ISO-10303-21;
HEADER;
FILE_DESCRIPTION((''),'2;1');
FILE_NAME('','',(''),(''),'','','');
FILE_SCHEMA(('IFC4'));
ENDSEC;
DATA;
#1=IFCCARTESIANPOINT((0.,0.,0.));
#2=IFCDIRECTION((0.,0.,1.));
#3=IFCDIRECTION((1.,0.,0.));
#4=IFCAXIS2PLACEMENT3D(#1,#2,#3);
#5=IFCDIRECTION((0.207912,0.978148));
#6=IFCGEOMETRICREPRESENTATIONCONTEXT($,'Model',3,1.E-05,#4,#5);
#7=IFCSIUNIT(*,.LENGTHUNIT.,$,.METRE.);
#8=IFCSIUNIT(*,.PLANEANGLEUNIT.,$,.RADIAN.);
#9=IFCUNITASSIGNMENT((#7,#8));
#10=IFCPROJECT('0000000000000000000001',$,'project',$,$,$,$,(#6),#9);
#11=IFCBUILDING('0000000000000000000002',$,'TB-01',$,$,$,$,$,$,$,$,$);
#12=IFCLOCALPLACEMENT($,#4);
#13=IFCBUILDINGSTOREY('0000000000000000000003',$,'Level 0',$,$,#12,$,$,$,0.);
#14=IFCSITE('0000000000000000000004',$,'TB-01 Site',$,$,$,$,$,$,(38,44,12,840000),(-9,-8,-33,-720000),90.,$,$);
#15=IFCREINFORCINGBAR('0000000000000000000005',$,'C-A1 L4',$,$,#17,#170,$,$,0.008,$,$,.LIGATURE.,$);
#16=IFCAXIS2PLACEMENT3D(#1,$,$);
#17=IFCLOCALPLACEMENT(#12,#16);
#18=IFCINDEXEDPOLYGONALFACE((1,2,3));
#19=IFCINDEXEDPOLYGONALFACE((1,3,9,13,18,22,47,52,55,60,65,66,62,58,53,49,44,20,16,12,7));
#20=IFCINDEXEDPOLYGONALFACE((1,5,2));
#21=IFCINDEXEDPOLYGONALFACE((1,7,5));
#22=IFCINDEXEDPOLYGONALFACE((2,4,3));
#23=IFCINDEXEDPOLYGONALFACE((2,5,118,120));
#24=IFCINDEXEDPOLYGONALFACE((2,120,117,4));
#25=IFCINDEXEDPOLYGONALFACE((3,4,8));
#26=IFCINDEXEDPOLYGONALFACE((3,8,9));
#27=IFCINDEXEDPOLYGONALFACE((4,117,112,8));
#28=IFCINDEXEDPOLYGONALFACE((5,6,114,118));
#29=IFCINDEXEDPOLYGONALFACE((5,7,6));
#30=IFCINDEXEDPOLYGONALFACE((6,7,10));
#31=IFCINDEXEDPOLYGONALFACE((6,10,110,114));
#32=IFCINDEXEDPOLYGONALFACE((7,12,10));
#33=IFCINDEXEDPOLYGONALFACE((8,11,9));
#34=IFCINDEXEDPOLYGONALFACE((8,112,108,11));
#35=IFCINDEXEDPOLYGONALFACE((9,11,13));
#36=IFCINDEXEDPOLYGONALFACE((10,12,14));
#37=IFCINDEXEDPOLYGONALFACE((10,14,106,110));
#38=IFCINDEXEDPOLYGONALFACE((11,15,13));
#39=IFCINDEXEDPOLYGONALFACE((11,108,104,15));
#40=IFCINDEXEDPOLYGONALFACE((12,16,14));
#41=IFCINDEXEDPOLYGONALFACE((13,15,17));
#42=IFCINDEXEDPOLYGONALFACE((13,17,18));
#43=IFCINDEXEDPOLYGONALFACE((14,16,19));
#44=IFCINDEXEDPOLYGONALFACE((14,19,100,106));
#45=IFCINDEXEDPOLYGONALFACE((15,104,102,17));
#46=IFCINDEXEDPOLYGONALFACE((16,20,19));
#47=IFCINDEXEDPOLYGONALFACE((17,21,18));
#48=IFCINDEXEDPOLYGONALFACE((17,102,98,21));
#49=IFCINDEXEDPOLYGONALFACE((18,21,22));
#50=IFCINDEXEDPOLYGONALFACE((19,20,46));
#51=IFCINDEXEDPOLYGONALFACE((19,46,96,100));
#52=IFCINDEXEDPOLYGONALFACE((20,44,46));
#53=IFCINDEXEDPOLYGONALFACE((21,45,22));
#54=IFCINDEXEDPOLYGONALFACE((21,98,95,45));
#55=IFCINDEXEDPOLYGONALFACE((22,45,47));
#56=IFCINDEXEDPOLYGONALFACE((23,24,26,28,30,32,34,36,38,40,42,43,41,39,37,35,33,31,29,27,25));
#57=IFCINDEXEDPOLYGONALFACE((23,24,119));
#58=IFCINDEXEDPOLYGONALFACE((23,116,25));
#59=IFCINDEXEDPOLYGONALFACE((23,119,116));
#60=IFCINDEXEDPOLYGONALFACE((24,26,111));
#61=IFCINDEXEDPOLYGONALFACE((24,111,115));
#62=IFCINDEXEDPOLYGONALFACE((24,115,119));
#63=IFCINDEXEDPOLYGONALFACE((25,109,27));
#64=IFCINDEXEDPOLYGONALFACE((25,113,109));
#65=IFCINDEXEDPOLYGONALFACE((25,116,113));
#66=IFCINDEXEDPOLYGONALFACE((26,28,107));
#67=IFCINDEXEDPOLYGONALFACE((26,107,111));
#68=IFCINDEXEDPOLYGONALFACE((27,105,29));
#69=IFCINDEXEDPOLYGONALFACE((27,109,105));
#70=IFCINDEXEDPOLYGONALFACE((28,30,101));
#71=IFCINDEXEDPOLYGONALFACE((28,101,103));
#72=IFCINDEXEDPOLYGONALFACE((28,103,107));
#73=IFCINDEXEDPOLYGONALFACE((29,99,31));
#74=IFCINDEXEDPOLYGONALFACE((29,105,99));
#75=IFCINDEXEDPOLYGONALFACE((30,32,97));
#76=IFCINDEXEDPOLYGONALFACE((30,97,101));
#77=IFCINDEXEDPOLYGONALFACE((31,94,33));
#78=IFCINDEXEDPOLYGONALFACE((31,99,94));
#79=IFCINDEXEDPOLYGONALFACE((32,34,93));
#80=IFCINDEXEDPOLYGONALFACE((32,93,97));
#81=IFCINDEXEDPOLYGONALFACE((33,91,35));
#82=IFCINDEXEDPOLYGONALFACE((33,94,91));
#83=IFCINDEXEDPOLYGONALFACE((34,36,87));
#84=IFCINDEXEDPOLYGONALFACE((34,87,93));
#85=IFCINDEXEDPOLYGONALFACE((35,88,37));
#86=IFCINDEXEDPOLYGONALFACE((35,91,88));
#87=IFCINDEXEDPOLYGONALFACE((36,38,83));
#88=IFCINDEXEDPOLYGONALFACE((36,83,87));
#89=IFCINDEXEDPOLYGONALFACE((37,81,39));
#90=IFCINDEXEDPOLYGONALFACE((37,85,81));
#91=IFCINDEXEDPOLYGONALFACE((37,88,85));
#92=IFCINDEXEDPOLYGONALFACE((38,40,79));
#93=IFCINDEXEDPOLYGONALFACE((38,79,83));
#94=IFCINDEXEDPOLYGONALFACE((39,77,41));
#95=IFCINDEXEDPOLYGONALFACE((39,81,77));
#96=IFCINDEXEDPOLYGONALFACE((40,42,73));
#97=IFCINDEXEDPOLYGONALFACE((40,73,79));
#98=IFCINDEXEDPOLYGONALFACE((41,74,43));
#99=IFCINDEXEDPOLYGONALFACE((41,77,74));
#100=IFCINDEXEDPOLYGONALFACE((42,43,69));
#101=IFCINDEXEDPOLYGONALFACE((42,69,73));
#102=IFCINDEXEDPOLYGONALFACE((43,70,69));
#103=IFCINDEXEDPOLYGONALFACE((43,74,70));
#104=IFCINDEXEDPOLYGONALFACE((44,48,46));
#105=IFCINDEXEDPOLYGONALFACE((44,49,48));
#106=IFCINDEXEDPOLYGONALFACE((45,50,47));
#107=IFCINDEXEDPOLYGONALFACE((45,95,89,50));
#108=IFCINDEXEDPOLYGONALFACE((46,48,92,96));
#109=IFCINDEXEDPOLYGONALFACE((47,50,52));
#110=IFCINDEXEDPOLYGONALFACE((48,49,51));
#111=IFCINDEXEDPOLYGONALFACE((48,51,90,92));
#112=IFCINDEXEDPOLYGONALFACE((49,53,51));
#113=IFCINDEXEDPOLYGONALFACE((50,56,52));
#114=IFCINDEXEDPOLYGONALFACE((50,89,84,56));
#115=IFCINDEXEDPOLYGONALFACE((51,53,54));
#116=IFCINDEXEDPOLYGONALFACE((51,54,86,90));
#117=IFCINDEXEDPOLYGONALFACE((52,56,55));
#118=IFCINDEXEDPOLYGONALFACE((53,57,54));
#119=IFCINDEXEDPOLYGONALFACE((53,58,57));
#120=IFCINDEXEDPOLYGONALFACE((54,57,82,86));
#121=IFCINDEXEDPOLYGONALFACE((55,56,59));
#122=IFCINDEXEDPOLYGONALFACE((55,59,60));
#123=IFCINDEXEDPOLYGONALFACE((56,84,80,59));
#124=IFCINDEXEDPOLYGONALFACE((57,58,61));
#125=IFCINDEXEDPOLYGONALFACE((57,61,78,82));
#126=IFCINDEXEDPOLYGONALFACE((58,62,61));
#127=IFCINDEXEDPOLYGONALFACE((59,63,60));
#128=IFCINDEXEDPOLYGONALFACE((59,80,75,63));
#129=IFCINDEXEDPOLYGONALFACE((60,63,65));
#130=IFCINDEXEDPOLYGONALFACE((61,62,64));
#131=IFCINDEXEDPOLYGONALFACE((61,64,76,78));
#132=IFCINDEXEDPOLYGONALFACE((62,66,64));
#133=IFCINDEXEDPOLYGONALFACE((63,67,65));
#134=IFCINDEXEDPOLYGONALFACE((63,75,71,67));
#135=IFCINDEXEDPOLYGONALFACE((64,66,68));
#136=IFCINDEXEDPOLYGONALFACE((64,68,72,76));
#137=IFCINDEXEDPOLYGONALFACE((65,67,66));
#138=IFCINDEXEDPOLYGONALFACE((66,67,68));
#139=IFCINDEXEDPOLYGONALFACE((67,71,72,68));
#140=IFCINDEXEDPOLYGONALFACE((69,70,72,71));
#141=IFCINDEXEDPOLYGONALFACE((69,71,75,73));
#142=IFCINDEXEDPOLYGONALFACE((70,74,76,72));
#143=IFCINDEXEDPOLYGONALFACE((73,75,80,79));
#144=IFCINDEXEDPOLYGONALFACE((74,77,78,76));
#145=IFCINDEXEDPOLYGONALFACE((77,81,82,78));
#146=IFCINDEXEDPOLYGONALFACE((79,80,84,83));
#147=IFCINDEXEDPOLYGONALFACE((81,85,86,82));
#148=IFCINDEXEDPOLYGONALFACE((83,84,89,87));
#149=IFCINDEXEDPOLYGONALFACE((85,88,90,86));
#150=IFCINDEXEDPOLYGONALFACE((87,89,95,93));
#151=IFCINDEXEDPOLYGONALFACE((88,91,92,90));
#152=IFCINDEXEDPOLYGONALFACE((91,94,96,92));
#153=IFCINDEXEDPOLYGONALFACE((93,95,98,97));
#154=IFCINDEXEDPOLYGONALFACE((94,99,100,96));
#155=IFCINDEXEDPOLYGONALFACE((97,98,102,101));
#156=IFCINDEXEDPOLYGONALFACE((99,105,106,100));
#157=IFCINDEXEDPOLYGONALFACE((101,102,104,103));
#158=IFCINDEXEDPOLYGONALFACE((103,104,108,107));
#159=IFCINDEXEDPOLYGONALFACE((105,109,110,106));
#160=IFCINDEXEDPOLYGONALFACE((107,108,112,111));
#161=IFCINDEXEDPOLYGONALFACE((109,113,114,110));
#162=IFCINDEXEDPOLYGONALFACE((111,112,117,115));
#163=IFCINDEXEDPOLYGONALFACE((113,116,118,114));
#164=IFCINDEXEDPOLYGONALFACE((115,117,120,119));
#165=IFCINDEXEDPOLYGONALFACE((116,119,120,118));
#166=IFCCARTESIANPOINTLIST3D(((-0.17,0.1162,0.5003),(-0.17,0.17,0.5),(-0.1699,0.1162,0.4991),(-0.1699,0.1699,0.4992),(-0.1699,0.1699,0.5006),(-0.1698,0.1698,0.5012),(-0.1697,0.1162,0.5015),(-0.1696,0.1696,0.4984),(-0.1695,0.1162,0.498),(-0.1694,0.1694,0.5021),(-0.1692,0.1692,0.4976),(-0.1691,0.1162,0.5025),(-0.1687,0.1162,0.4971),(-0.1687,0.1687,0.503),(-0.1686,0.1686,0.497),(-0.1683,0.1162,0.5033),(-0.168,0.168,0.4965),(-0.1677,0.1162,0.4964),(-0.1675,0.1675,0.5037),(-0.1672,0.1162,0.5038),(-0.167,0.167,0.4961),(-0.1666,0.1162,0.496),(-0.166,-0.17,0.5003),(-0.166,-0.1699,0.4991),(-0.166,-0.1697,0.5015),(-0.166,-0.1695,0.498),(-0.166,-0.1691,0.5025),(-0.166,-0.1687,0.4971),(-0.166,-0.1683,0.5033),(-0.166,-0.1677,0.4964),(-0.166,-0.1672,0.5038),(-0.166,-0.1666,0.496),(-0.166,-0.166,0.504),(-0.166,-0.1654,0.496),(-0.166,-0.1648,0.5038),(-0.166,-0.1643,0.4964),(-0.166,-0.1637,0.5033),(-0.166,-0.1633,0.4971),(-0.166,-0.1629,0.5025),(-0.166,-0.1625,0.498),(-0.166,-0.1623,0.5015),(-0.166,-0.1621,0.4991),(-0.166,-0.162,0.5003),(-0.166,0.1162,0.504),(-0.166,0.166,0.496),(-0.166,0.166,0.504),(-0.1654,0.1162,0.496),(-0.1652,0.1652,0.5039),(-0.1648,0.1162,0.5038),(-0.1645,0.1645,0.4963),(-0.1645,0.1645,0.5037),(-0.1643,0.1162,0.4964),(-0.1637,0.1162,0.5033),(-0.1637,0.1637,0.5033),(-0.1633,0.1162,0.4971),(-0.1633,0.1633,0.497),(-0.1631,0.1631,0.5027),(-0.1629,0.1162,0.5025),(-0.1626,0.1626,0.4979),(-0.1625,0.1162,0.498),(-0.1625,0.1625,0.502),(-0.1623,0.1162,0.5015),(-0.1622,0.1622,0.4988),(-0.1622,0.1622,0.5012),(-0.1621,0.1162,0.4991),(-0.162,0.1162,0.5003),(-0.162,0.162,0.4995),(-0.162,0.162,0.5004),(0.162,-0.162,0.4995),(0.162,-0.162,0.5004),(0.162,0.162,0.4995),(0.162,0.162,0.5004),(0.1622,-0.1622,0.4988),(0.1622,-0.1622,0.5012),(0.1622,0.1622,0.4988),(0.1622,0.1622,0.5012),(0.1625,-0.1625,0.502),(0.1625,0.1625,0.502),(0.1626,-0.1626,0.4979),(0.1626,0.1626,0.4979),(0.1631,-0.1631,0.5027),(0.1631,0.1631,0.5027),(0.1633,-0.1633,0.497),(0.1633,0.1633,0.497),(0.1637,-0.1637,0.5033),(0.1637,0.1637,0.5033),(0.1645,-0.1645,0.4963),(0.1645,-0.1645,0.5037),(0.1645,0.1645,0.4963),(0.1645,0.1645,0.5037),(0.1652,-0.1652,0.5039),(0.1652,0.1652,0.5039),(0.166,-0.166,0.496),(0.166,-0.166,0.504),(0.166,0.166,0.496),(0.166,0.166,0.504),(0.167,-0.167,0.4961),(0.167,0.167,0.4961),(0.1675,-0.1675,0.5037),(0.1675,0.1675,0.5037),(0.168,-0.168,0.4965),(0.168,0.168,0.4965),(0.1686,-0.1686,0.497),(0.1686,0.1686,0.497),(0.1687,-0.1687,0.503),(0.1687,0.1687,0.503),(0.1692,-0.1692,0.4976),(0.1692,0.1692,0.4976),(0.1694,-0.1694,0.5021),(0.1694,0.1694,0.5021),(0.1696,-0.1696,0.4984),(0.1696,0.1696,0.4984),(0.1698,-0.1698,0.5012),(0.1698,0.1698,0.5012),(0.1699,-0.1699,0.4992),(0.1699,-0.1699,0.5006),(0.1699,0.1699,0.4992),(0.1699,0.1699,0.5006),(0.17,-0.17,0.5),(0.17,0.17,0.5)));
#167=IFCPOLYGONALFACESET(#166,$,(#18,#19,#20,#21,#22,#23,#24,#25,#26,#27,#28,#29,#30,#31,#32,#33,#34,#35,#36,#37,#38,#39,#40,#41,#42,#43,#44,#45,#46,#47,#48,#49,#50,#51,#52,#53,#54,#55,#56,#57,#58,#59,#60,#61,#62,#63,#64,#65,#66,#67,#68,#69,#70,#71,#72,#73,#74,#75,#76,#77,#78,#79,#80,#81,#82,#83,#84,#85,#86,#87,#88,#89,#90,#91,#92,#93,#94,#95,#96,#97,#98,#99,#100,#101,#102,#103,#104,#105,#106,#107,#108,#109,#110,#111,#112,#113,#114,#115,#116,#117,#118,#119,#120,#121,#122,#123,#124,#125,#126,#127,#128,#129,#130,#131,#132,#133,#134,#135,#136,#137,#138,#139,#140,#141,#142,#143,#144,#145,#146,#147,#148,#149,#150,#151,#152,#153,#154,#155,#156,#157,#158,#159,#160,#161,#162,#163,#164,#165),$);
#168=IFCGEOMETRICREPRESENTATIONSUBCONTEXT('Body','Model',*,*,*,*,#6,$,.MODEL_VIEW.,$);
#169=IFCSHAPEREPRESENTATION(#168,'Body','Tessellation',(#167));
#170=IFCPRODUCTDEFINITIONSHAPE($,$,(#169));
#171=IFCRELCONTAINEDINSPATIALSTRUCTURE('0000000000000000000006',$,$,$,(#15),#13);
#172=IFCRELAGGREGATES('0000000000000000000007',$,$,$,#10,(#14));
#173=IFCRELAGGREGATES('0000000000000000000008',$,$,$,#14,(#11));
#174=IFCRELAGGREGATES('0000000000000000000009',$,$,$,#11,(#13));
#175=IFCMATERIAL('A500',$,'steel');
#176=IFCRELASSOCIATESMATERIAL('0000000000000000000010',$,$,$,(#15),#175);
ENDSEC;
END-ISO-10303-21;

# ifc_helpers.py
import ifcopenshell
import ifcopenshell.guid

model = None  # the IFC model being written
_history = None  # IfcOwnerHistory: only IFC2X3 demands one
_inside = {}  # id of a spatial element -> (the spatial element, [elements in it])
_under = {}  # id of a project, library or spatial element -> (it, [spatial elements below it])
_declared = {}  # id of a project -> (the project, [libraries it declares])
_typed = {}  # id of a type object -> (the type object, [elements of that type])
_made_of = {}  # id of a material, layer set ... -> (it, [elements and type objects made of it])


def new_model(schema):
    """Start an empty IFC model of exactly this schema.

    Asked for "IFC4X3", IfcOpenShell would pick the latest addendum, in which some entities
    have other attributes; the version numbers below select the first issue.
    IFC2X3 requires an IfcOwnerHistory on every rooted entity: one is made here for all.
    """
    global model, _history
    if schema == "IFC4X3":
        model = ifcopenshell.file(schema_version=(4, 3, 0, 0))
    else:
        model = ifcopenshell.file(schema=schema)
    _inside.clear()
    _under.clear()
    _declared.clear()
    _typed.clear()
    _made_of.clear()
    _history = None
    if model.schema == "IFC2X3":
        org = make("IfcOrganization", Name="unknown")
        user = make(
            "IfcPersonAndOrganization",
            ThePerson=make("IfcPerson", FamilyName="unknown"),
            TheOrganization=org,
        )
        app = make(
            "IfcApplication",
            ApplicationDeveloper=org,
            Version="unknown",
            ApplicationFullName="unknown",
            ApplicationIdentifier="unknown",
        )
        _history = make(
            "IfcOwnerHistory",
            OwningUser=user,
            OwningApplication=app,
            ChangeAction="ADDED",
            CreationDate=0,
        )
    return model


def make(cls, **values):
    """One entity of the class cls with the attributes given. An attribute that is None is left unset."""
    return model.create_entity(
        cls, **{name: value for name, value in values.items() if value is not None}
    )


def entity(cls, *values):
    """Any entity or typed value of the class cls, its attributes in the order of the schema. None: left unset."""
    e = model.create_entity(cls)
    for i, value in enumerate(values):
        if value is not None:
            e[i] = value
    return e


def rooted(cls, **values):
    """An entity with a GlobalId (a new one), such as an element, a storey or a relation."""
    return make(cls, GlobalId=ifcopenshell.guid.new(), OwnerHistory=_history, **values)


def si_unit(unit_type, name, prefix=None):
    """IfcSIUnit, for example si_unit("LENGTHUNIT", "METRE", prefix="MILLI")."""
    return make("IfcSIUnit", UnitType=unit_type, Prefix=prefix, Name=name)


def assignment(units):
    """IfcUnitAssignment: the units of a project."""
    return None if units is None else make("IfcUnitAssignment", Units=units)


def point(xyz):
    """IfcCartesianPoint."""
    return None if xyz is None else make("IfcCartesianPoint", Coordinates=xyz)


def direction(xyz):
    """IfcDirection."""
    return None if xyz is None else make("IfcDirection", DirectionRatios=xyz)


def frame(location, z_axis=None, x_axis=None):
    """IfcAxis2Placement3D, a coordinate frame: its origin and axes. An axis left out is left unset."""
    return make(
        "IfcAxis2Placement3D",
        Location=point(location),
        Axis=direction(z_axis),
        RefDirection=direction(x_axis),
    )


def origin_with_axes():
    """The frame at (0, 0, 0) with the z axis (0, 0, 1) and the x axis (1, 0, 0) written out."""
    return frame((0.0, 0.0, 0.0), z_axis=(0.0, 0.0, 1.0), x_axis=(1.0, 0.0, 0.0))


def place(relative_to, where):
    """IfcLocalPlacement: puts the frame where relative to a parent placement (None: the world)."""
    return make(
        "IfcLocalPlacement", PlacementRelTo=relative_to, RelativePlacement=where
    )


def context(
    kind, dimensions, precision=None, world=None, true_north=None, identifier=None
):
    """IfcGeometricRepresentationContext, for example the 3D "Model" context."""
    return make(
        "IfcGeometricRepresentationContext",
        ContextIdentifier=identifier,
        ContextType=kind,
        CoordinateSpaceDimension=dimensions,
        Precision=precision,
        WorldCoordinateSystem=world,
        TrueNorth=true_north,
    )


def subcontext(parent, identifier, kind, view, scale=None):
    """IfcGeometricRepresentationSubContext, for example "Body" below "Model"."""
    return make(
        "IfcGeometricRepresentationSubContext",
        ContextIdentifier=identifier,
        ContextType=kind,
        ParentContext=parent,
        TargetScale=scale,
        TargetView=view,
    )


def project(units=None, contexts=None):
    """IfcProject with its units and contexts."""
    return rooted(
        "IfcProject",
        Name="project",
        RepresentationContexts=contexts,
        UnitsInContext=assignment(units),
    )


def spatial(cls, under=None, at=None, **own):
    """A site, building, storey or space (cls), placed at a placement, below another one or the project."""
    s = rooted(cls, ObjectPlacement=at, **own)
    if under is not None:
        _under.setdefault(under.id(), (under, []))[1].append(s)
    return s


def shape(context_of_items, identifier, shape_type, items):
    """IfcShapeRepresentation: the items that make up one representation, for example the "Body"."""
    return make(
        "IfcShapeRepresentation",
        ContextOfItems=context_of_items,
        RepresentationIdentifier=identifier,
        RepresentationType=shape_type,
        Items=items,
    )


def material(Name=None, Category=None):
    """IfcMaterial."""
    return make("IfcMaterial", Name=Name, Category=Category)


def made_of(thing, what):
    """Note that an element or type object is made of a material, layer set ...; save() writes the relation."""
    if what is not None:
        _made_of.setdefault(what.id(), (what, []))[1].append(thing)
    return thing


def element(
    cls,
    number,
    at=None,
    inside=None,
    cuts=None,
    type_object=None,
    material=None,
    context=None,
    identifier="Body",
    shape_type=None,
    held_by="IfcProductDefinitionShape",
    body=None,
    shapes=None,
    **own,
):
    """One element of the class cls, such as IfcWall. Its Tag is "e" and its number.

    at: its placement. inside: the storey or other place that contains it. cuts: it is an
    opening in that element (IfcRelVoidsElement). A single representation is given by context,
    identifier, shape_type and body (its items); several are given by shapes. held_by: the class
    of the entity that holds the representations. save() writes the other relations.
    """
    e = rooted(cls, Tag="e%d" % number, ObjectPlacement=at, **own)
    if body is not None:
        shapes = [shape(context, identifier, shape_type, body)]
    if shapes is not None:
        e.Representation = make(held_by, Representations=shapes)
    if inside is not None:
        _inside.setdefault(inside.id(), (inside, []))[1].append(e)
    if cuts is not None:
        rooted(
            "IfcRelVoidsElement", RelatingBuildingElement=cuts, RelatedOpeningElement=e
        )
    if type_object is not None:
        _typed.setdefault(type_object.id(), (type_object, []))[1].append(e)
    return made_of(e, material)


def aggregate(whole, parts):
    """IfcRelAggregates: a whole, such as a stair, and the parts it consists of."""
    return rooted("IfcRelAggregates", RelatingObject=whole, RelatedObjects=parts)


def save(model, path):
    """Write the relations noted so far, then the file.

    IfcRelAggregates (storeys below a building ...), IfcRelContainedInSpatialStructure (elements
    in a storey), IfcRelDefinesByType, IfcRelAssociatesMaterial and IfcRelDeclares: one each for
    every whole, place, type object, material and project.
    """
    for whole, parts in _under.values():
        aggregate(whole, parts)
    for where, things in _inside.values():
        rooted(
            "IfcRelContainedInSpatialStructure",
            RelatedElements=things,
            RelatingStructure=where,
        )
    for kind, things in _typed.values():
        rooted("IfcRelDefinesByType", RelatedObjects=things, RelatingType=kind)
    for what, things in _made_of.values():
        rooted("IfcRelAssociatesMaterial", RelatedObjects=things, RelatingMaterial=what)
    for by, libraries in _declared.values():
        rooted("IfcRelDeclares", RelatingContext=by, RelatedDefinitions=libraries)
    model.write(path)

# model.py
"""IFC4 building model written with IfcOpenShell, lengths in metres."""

from ifc_helpers import new_model, entity, si_unit, direction, origin_with_axes, place, context, subcontext, project, spatial, material, element, save


model = new_model("IFC4")

# Units and contexts
model_context = context("Model", 3, precision=1e-05, world=origin_with_axes(), true_north=direction((0.207912, 0.978148)))
body_context = subcontext(model_context, "Body", "Model", "MODEL_VIEW")
ifc_project = project(units=[si_unit("LENGTHUNIT", "METRE"), si_unit("PLANEANGLEUNIT", "RADIAN")], contexts=[model_context])

# Site, building, storey
site = spatial("IfcSite", under=ifc_project, Name="TB-01 Site", RefLatitude=(38, 44, 12, 840000), RefLongitude=(-9, -8, -33, -720000), RefElevation=90.0)
building = spatial("IfcBuilding", under=site, Name="TB-01")
storey_placement = place(None, origin_with_axes())
storey = spatial("IfcBuildingStorey", under=building, at=storey_placement, Name="Level 0", Elevation=0.0)

# Reinforcing bar
ifc_material_1 = material(Name="A500", Category="steel")
reinforcing_bar_1_placement = place(storey_placement, origin_with_axes())
element("IfcReinforcingBar", 1, at=reinforcing_bar_1_placement, inside=storey, material=ifc_material_1, Name="C-A1 L4", NominalDiameter=0.008, PredefinedType="LIGATURE", context=body_context, shape_type="AdvancedSweptSolid", body=[
    entity("IfcSweptDiskSolid", entity("IfcPolyline", [entity("IfcCartesianPoint", [-0.166, -0.166, 0.5]), entity("IfcCartesianPoint", [0.166, -0.166, 0.5]), entity("IfcCartesianPoint", [0.166, 0.166, 0.5]), entity("IfcCartesianPoint", [-0.166, 0.166, 0.5]), entity("IfcCartesianPoint", [-0.166, 0.1162, 0.5])]), 0.004),
])

save(model, "model.ifc")
